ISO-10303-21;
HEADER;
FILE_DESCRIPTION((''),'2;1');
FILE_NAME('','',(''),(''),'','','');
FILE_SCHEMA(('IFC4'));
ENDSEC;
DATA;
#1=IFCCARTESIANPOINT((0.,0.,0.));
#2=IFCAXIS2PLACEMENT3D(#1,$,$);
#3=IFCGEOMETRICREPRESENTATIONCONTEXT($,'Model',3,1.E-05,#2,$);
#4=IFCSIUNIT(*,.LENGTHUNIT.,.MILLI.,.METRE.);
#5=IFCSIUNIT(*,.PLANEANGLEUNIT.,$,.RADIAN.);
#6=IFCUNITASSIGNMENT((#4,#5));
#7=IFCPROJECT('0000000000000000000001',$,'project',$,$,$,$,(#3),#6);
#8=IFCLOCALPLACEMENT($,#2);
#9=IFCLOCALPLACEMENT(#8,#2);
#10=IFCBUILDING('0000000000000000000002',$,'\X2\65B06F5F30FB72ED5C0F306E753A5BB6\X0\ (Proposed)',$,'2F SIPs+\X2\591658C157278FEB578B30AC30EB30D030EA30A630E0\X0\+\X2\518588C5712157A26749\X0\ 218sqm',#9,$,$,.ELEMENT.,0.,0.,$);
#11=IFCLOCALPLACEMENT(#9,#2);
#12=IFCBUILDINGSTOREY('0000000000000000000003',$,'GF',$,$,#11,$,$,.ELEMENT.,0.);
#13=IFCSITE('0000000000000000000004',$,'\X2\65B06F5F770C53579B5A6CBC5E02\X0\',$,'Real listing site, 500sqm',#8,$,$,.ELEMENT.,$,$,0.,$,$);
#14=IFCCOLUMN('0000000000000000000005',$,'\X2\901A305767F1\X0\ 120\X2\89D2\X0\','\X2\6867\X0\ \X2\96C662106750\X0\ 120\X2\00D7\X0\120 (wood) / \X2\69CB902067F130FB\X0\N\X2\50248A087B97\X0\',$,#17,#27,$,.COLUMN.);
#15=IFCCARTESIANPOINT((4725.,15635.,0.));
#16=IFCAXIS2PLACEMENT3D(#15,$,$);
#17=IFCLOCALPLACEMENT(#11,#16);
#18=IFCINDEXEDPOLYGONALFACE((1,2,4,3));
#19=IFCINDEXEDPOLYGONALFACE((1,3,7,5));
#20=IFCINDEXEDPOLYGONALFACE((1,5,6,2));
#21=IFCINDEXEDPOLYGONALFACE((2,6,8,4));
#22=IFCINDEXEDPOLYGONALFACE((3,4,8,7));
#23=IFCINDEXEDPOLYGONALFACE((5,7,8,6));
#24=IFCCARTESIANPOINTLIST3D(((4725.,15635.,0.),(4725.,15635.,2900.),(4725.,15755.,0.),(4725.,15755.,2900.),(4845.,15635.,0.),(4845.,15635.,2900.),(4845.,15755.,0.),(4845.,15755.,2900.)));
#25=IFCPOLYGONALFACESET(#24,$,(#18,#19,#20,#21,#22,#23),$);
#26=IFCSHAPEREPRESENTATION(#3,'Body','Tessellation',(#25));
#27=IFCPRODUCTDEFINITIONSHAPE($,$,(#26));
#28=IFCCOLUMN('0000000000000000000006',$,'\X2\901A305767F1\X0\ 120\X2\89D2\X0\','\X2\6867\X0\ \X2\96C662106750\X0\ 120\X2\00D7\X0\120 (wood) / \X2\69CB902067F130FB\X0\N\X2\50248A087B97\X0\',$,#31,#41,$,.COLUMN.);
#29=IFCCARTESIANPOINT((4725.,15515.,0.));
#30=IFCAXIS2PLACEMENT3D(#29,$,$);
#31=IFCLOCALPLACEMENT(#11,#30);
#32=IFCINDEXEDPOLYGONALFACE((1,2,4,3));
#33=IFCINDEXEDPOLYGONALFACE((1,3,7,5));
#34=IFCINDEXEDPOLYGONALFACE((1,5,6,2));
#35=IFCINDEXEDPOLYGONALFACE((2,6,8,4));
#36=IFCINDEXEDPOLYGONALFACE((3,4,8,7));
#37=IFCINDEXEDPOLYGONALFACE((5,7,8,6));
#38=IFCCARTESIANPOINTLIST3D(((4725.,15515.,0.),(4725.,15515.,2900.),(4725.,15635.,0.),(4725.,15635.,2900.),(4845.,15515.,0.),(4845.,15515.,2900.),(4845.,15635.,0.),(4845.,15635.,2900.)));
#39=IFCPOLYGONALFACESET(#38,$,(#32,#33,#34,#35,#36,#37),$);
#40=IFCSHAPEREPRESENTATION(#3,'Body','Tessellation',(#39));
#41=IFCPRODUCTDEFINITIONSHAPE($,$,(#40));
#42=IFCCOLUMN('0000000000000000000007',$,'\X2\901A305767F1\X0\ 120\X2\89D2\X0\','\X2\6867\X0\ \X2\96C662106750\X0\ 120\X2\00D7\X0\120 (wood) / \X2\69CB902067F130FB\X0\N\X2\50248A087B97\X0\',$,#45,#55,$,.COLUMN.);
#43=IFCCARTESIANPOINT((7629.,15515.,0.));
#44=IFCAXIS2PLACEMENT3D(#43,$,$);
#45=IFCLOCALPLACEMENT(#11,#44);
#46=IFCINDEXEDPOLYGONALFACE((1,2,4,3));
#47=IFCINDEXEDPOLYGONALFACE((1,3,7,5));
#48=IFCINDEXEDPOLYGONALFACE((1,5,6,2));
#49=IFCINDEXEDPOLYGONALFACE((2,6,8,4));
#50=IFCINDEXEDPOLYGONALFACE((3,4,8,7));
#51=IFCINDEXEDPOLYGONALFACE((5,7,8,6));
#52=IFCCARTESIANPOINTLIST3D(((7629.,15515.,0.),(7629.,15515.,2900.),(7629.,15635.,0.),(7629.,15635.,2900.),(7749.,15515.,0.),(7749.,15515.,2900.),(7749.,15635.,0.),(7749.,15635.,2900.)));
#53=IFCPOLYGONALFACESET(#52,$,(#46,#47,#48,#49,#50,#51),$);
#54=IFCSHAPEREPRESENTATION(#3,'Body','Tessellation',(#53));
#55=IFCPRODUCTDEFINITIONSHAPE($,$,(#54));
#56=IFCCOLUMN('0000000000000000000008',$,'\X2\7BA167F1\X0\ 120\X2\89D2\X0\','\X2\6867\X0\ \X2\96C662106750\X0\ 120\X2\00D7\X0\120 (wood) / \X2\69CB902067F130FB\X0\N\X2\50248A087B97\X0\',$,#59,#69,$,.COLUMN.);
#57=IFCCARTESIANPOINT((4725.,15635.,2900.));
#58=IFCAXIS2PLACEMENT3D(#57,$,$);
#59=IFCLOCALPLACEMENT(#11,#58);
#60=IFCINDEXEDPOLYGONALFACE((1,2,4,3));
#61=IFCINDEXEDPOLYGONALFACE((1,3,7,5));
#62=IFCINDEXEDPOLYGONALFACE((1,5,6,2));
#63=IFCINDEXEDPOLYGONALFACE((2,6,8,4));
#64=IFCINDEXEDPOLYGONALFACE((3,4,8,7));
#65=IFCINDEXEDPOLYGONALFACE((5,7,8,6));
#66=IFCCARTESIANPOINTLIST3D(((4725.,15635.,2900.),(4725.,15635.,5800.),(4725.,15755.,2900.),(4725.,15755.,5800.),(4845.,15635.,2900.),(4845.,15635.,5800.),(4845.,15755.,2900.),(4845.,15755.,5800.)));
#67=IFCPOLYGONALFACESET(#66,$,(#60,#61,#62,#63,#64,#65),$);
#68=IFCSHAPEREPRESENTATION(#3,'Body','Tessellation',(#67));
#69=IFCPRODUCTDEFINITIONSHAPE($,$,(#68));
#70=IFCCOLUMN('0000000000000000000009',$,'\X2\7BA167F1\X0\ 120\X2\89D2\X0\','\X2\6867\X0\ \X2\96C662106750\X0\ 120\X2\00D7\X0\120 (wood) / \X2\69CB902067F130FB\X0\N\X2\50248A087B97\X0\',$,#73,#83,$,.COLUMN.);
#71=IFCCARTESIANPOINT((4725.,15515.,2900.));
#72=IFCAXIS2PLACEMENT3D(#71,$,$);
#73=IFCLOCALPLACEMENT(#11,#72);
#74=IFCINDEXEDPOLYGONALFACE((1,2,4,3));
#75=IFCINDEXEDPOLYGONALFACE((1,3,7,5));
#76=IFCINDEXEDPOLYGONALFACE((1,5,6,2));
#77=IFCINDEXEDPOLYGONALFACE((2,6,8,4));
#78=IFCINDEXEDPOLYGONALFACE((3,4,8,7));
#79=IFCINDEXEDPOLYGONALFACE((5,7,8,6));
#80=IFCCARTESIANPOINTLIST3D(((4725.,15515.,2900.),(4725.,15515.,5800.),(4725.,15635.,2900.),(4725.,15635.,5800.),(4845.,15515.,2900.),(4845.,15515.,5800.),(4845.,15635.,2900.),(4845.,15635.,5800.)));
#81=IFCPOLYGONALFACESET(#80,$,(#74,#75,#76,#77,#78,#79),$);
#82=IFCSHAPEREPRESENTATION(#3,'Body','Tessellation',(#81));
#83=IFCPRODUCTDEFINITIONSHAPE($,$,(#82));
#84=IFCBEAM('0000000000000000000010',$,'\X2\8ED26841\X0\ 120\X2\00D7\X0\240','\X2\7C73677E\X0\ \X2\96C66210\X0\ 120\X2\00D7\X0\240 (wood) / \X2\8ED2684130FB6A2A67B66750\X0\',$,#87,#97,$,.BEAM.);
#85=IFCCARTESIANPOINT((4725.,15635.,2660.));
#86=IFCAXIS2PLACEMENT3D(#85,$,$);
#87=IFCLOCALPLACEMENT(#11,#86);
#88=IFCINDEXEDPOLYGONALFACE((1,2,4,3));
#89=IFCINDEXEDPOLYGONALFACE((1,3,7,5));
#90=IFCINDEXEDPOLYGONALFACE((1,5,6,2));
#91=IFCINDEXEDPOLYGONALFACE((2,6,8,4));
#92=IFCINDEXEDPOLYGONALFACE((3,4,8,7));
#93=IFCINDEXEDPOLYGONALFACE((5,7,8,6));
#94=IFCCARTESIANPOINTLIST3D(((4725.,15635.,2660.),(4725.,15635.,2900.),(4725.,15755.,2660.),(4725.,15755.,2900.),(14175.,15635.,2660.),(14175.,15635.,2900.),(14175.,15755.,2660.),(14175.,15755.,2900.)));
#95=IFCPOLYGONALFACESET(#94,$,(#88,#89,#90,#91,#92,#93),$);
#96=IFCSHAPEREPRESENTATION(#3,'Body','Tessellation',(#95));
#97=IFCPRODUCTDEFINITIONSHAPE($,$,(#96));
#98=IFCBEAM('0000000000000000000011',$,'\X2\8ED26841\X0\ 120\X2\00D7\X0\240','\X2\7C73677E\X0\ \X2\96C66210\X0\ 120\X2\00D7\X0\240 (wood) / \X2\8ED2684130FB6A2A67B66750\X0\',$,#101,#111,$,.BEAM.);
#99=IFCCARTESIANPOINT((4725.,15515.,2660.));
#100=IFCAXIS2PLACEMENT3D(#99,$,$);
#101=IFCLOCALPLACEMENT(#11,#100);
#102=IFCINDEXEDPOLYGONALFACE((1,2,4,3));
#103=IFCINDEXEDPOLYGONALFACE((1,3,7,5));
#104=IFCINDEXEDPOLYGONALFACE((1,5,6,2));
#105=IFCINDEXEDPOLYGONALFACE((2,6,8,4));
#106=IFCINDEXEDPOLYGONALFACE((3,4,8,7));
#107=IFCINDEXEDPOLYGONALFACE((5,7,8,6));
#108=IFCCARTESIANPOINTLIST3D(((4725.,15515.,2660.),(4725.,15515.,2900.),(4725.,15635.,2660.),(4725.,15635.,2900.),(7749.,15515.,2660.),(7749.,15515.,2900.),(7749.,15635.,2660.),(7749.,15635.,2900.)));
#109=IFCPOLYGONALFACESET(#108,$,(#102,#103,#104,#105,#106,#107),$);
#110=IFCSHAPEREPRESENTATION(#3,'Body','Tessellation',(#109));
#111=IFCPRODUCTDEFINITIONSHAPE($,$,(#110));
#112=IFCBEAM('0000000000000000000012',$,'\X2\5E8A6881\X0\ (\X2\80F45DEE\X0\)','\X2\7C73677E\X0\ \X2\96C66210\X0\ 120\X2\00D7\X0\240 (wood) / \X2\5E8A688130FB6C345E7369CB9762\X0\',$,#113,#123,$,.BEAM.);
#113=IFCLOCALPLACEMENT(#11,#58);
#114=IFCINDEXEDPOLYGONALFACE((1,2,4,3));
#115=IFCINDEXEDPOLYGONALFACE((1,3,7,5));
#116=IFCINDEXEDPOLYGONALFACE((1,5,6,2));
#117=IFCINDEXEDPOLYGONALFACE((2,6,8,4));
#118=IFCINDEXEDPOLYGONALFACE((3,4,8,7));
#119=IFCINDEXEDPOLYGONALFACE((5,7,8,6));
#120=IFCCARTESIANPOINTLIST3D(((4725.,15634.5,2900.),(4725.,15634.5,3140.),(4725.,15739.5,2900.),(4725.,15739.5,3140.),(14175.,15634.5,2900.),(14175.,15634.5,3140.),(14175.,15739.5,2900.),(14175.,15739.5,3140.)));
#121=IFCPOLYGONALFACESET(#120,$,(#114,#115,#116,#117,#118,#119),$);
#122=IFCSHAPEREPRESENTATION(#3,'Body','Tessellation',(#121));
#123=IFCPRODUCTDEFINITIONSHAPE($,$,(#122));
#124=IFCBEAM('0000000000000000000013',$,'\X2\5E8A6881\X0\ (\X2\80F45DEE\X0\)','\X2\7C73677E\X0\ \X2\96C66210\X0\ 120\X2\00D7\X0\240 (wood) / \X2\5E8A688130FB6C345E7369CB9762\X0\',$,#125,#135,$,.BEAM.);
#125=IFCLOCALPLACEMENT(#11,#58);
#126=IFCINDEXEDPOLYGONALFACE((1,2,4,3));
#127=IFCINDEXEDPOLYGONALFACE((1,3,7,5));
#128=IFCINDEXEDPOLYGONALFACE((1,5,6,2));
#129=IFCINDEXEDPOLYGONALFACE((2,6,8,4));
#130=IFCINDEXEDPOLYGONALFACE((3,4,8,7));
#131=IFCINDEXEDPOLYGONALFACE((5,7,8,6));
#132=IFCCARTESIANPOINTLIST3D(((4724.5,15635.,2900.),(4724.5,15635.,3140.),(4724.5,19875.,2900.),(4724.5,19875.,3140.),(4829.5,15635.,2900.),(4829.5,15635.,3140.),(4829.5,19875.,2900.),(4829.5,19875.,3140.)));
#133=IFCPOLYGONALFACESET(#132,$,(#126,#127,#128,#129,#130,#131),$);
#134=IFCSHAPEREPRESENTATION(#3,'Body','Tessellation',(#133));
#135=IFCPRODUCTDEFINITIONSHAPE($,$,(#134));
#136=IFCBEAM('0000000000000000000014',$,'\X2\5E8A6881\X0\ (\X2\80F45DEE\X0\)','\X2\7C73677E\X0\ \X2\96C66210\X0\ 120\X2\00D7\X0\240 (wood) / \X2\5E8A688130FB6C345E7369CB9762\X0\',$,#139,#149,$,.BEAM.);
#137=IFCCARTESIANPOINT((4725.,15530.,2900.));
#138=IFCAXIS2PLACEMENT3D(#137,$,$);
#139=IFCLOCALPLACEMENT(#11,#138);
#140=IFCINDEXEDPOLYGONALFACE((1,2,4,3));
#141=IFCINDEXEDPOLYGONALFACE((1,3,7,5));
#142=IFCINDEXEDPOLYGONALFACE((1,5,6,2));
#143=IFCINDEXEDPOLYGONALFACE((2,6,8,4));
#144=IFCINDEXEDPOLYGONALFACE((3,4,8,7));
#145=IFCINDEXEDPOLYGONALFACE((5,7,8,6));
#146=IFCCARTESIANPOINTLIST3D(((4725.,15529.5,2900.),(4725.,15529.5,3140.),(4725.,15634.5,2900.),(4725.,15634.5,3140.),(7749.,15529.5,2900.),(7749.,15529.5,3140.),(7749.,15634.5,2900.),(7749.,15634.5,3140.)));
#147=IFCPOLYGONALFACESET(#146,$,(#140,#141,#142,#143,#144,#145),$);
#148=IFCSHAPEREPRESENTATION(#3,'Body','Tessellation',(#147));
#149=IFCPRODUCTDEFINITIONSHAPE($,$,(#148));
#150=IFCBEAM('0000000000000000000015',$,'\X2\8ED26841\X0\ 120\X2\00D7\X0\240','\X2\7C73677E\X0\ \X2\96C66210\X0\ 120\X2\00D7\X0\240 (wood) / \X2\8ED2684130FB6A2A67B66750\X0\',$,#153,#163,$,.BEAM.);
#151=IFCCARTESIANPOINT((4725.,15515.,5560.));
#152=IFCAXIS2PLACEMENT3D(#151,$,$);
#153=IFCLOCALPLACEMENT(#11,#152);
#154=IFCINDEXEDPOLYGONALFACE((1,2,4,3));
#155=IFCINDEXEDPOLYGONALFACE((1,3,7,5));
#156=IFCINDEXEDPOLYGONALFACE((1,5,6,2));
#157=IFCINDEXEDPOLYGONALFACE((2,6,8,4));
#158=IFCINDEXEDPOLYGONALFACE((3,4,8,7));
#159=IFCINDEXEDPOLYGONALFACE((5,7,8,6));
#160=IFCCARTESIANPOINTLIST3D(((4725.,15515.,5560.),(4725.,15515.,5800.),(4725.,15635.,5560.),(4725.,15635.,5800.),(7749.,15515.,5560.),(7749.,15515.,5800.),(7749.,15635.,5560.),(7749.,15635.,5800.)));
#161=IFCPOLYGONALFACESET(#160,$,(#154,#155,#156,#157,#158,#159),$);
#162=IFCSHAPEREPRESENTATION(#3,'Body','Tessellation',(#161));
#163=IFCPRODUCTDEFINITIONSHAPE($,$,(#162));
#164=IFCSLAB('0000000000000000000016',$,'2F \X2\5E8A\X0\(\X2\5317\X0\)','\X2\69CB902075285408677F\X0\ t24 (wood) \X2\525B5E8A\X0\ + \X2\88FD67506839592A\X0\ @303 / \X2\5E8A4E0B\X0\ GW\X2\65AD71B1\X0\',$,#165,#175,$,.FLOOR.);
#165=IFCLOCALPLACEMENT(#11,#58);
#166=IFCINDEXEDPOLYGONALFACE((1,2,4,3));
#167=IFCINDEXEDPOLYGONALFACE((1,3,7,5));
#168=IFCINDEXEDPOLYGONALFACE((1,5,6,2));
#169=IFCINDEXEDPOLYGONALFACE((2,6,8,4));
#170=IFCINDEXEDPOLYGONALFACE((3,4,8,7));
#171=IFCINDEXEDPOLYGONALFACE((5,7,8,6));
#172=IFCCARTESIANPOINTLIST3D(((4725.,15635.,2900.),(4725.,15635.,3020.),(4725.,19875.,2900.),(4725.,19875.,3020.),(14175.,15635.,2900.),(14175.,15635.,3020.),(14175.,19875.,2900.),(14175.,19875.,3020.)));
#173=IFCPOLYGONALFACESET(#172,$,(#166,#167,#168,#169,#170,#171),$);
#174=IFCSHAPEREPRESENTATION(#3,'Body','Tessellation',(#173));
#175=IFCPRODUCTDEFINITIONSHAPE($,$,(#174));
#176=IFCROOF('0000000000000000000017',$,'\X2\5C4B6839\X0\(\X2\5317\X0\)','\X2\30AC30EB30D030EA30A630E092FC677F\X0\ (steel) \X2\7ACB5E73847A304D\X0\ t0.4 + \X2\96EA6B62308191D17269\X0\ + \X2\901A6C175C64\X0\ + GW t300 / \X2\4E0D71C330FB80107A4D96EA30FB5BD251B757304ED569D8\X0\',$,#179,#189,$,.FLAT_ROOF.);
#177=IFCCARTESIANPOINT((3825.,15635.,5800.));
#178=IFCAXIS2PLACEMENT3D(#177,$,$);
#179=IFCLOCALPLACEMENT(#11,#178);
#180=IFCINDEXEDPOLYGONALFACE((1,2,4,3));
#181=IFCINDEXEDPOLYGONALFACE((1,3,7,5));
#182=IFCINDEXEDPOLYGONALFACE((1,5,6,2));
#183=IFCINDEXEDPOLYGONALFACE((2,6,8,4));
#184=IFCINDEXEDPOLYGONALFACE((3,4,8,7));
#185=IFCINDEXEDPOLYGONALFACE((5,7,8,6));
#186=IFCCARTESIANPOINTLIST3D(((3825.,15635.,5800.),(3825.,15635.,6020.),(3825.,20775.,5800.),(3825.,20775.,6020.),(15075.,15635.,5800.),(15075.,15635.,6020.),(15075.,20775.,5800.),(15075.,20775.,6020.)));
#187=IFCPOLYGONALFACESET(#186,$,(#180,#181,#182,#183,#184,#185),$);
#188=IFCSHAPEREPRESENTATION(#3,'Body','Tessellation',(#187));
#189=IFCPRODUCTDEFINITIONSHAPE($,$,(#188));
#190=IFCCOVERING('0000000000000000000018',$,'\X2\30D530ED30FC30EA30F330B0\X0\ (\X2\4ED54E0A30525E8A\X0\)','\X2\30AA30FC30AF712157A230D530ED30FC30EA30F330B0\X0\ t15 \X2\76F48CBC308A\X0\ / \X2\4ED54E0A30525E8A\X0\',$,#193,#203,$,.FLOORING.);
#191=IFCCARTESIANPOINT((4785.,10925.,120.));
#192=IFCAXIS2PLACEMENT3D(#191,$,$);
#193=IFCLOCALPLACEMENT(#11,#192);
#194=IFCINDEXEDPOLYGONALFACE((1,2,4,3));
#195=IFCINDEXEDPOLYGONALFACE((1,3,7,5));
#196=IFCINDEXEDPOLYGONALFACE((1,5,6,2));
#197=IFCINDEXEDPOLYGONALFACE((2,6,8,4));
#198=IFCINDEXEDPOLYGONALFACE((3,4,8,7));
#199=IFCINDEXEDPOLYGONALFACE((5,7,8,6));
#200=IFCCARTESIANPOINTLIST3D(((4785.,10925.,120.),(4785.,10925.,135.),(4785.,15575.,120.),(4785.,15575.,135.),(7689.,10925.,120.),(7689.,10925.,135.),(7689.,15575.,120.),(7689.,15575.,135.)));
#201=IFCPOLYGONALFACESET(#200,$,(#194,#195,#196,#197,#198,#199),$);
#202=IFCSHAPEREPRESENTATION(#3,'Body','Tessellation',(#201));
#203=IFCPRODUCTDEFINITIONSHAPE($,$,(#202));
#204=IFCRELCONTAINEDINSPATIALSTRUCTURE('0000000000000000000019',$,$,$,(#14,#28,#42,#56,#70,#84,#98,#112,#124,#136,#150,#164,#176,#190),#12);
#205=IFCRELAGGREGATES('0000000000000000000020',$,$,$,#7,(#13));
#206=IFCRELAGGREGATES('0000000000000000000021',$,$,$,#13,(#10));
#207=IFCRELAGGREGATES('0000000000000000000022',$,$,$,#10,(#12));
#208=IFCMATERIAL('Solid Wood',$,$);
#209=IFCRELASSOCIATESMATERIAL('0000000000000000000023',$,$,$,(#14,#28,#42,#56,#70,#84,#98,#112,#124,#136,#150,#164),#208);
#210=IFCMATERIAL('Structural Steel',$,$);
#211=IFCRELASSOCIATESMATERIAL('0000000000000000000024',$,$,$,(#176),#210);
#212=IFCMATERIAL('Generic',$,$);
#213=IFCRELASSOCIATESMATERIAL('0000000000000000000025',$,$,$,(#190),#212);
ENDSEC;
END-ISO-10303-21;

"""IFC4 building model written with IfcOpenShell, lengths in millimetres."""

from ifc_helpers import new_model, si_unit, frame, frame_2d, origin, place, context, project, spatial, rectangle, extrude, material, element, save


model = new_model("IFC4")

# Units and contexts
model_context = context("Model", 3, precision=1e-05, world=origin())
ifc_project = project(units=[si_unit("LENGTHUNIT", "METRE", prefix="MILLI"), si_unit("PLANEANGLEUNIT", "RADIAN")], contexts=[model_context])

# Site, building, storey
site_placement = place(None, origin())
site = spatial("IfcSite", under=ifc_project, at=site_placement, Name="新潟県南魚沼市", ObjectType="Real listing site, 500sqm", CompositionType="ELEMENT", RefElevation=0.0)
building_placement = place(site_placement, origin())
building = spatial("IfcBuilding", under=site, at=building_placement, Name="新潟・狭小の町家 (Proposed)", ObjectType="2F SIPs+外壁圧迫型ガルバリウム+内装無垢杉 218sqm", CompositionType="ELEMENT", ElevationOfRefHeight=0.0, ElevationOfTerrain=0.0)
storey_placement = place(building_placement, origin())
storey = spatial("IfcBuildingStorey", under=building, at=storey_placement, Name="GF", CompositionType="ELEMENT", Elevation=0.0)

# Columns
ifc_material_1 = material(Name="Solid Wood")
column_1_placement = place(storey_placement, frame((4725.0, 15635.0, 0.0)))
element("IfcColumn", 1, at=column_1_placement, inside=storey, material=ifc_material_1, Name="通し柱 120角", Description="桧 集成材 120×120 (wood) / 構造柱・N値計算", PredefinedType="COLUMN", context=model_context, shape_type="SweptSolid", body=[
    extrude(rectangle(XDim=120.0, YDim=120.0, at=frame_2d((60.0, 60.0))), frame((4725.0, 15635.0, 0.0)), (0.0, 0.0, 1.0), 2900.0),
])
column_2_placement = place(storey_placement, frame((4725.0, 15515.0, 0.0)))
element("IfcColumn", 2, at=column_2_placement, inside=storey, material=ifc_material_1, Name="通し柱 120角", Description="桧 集成材 120×120 (wood) / 構造柱・N値計算", PredefinedType="COLUMN", context=model_context, shape_type="SweptSolid", body=[
    extrude(rectangle(XDim=120.0, YDim=120.0, at=frame_2d((60.0, 60.0))), frame((4725.0, 15515.0, 0.0)), (0.0, 0.0, 1.0), 2900.0),
])
column_3_placement = place(storey_placement, frame((7629.0, 15515.0, 0.0)))
element("IfcColumn", 3, at=column_3_placement, inside=storey, material=ifc_material_1, Name="通し柱 120角", Description="桧 集成材 120×120 (wood) / 構造柱・N値計算", PredefinedType="COLUMN", context=model_context, shape_type="SweptSolid", body=[
    extrude(rectangle(XDim=120.0, YDim=120.0, at=frame_2d((60.0, 60.0))), frame((7629.0, 15515.0, 0.0)), (0.0, 0.0, 1.0), 2900.0),
])
column_4_placement = place(storey_placement, frame((4725.0, 15635.0, 2900.0)))
element("IfcColumn", 4, at=column_4_placement, inside=storey, material=ifc_material_1, Name="管柱 120角", Description="桧 集成材 120×120 (wood) / 構造柱・N値計算", PredefinedType="COLUMN", context=model_context, shape_type="SweptSolid", body=[
    extrude(rectangle(XDim=120.0, YDim=120.0, at=frame_2d((60.0, 60.0))), frame((4725.0, 15635.0, 2900.0)), (0.0, 0.0, 1.0), 2900.0),
])
column_5_placement = place(storey_placement, frame((4725.0, 15515.0, 2900.0)))
element("IfcColumn", 5, at=column_5_placement, inside=storey, material=ifc_material_1, Name="管柱 120角", Description="桧 集成材 120×120 (wood) / 構造柱・N値計算", PredefinedType="COLUMN", context=model_context, shape_type="SweptSolid", body=[
    extrude(rectangle(XDim=120.0, YDim=120.0, at=frame_2d((60.0, 60.0))), frame((4725.0, 15515.0, 2900.0)), (0.0, 0.0, 1.0), 2900.0),
])

# Beams
beam_1_placement = place(storey_placement, frame((4725.0, 15635.0, 2660.0)))
element("IfcBeam", 6, at=beam_1_placement, inside=storey, material=ifc_material_1, Name="軒桁 120×240", Description="米松 集成 120×240 (wood) / 軒桁・横架材", PredefinedType="BEAM", context=model_context, shape_type="SweptSolid", body=[
    extrude(rectangle(XDim=9450.0, YDim=120.0, at=frame_2d((4725.0, 60.0))), frame((4725.0, 15635.0, 2660.0)), (0.0, 0.0, 1.0), 240.0),
])
beam_2_placement = place(storey_placement, frame((4725.0, 15515.0, 2660.0)))
element("IfcBeam", 7, at=beam_2_placement, inside=storey, material=ifc_material_1, Name="軒桁 120×240", Description="米松 集成 120×240 (wood) / 軒桁・横架材", PredefinedType="BEAM", context=model_context, shape_type="SweptSolid", body=[
    extrude(rectangle(XDim=3024.0, YDim=120.0, at=frame_2d((1512.0, 60.0))), frame((4725.0, 15515.0, 2660.0)), (0.0, 0.0, 1.0), 240.0),
])
beam_3_placement = place(storey_placement, frame((4725.0, 15635.0, 2900.0)))
element("IfcBeam", 8, at=beam_3_placement, inside=storey, material=ifc_material_1, Name="床梁 (胴差)", Description="米松 集成 120×240 (wood) / 床梁・水平構面", PredefinedType="BEAM", context=model_context, shape_type="SweptSolid", body=[
    extrude(rectangle(XDim=9450.0, YDim=105.0, at=frame_2d((4725.0, 52.0))), frame((4725.0, 15635.0, 2900.0)), (0.0, 0.0, 1.0), 240.0),
])
beam_4_placement = place(storey_placement, frame((4725.0, 15635.0, 2900.0)))
element("IfcBeam", 9, at=beam_4_placement, inside=storey, material=ifc_material_1, Name="床梁 (胴差)", Description="米松 集成 120×240 (wood) / 床梁・水平構面", PredefinedType="BEAM", context=model_context, shape_type="SweptSolid", body=[
    extrude(rectangle(XDim=105.0, YDim=4240.0, at=frame_2d((52.0, 2120.0))), frame((4725.0, 15635.0, 2900.0)), (0.0, 0.0, 1.0), 240.0),
])
beam_5_placement = place(storey_placement, frame((4725.0, 15530.0, 2900.0)))
element("IfcBeam", 10, at=beam_5_placement, inside=storey, material=ifc_material_1, Name="床梁 (胴差)", Description="米松 集成 120×240 (wood) / 床梁・水平構面", PredefinedType="BEAM", context=model_context, shape_type="SweptSolid", body=[
    extrude(rectangle(XDim=3024.0, YDim=105.0, at=frame_2d((1512.0, 52.0))), frame((4725.0, 15530.0, 2900.0)), (0.0, 0.0, 1.0), 240.0),
])
beam_6_placement = place(storey_placement, frame((4725.0, 15515.0, 5560.0)))
element("IfcBeam", 11, at=beam_6_placement, inside=storey, material=ifc_material_1, Name="軒桁 120×240", Description="米松 集成 120×240 (wood) / 軒桁・横架材", PredefinedType="BEAM", context=model_context, shape_type="SweptSolid", body=[
    extrude(rectangle(XDim=3024.0, YDim=120.0, at=frame_2d((1512.0, 60.0))), frame((4725.0, 15515.0, 5560.0)), (0.0, 0.0, 1.0), 240.0),
])

# Slab
slab_1_placement = place(storey_placement, frame((4725.0, 15635.0, 2900.0)))
element("IfcSlab", 12, at=slab_1_placement, inside=storey, material=ifc_material_1, Name="2F 床(北)", Description="構造用合板 t24 (wood) 剛床 + 製材根太 @303 / 床下 GW断熱", PredefinedType="FLOOR", context=model_context, shape_type="SweptSolid", body=[
    extrude(rectangle(XDim=9450.0, YDim=4240.0, at=frame_2d((4725.0, 2120.0))), frame((4725.0, 15635.0, 2900.0)), (0.0, 0.0, 1.0), 120.0),
])

# Roof
ifc_material_2 = material(Name="Structural Steel")
for number, where, name in (
    (13, (3825.0, 15635.0, 5800.0), "屋根(北)"),
):
    element("IfcRoof", number, at=place(storey_placement, frame(where)), inside=storey, material=ifc_material_2, Name=name, Description="ガルバリウム鋼板 (steel) 立平葺き t0.4 + 雪止め金物 + 通気層 + GW t300 / 不燃・耐積雪・寒冷地仕様", PredefinedType="FLAT_ROOF", context=model_context, shape_type="SweptSolid", body=[
        extrude(rectangle(XDim=11250.0, YDim=5140.0, at=frame_2d((5625.0, 2570.0))), frame((3825.0, 15635.0, 5800.0)), (0.0, 0.0, 1.0), 220.0),
    ])

# Covering
ifc_material_3 = material(Name="Generic")
covering_1_placement = place(storey_placement, frame((4785.0, 10925.0, 120.0)))
element("IfcCovering", 14, at=covering_1_placement, inside=storey, material=ifc_material_3, Name="フローリング (仕上げ床)", Description="オーク無垢フローリング t15 直貼り / 仕上げ床", PredefinedType="FLOORING", context=model_context, shape_type="SweptSolid", body=[
    extrude(rectangle(XDim=2904.0, YDim=4650.0, at=frame_2d((1452.0, 2325.0))), frame((4785.0, 10925.0, 120.0)), (0.0, 0.0, 1.0), 15.0),
])

save(model, "model.ifc")
